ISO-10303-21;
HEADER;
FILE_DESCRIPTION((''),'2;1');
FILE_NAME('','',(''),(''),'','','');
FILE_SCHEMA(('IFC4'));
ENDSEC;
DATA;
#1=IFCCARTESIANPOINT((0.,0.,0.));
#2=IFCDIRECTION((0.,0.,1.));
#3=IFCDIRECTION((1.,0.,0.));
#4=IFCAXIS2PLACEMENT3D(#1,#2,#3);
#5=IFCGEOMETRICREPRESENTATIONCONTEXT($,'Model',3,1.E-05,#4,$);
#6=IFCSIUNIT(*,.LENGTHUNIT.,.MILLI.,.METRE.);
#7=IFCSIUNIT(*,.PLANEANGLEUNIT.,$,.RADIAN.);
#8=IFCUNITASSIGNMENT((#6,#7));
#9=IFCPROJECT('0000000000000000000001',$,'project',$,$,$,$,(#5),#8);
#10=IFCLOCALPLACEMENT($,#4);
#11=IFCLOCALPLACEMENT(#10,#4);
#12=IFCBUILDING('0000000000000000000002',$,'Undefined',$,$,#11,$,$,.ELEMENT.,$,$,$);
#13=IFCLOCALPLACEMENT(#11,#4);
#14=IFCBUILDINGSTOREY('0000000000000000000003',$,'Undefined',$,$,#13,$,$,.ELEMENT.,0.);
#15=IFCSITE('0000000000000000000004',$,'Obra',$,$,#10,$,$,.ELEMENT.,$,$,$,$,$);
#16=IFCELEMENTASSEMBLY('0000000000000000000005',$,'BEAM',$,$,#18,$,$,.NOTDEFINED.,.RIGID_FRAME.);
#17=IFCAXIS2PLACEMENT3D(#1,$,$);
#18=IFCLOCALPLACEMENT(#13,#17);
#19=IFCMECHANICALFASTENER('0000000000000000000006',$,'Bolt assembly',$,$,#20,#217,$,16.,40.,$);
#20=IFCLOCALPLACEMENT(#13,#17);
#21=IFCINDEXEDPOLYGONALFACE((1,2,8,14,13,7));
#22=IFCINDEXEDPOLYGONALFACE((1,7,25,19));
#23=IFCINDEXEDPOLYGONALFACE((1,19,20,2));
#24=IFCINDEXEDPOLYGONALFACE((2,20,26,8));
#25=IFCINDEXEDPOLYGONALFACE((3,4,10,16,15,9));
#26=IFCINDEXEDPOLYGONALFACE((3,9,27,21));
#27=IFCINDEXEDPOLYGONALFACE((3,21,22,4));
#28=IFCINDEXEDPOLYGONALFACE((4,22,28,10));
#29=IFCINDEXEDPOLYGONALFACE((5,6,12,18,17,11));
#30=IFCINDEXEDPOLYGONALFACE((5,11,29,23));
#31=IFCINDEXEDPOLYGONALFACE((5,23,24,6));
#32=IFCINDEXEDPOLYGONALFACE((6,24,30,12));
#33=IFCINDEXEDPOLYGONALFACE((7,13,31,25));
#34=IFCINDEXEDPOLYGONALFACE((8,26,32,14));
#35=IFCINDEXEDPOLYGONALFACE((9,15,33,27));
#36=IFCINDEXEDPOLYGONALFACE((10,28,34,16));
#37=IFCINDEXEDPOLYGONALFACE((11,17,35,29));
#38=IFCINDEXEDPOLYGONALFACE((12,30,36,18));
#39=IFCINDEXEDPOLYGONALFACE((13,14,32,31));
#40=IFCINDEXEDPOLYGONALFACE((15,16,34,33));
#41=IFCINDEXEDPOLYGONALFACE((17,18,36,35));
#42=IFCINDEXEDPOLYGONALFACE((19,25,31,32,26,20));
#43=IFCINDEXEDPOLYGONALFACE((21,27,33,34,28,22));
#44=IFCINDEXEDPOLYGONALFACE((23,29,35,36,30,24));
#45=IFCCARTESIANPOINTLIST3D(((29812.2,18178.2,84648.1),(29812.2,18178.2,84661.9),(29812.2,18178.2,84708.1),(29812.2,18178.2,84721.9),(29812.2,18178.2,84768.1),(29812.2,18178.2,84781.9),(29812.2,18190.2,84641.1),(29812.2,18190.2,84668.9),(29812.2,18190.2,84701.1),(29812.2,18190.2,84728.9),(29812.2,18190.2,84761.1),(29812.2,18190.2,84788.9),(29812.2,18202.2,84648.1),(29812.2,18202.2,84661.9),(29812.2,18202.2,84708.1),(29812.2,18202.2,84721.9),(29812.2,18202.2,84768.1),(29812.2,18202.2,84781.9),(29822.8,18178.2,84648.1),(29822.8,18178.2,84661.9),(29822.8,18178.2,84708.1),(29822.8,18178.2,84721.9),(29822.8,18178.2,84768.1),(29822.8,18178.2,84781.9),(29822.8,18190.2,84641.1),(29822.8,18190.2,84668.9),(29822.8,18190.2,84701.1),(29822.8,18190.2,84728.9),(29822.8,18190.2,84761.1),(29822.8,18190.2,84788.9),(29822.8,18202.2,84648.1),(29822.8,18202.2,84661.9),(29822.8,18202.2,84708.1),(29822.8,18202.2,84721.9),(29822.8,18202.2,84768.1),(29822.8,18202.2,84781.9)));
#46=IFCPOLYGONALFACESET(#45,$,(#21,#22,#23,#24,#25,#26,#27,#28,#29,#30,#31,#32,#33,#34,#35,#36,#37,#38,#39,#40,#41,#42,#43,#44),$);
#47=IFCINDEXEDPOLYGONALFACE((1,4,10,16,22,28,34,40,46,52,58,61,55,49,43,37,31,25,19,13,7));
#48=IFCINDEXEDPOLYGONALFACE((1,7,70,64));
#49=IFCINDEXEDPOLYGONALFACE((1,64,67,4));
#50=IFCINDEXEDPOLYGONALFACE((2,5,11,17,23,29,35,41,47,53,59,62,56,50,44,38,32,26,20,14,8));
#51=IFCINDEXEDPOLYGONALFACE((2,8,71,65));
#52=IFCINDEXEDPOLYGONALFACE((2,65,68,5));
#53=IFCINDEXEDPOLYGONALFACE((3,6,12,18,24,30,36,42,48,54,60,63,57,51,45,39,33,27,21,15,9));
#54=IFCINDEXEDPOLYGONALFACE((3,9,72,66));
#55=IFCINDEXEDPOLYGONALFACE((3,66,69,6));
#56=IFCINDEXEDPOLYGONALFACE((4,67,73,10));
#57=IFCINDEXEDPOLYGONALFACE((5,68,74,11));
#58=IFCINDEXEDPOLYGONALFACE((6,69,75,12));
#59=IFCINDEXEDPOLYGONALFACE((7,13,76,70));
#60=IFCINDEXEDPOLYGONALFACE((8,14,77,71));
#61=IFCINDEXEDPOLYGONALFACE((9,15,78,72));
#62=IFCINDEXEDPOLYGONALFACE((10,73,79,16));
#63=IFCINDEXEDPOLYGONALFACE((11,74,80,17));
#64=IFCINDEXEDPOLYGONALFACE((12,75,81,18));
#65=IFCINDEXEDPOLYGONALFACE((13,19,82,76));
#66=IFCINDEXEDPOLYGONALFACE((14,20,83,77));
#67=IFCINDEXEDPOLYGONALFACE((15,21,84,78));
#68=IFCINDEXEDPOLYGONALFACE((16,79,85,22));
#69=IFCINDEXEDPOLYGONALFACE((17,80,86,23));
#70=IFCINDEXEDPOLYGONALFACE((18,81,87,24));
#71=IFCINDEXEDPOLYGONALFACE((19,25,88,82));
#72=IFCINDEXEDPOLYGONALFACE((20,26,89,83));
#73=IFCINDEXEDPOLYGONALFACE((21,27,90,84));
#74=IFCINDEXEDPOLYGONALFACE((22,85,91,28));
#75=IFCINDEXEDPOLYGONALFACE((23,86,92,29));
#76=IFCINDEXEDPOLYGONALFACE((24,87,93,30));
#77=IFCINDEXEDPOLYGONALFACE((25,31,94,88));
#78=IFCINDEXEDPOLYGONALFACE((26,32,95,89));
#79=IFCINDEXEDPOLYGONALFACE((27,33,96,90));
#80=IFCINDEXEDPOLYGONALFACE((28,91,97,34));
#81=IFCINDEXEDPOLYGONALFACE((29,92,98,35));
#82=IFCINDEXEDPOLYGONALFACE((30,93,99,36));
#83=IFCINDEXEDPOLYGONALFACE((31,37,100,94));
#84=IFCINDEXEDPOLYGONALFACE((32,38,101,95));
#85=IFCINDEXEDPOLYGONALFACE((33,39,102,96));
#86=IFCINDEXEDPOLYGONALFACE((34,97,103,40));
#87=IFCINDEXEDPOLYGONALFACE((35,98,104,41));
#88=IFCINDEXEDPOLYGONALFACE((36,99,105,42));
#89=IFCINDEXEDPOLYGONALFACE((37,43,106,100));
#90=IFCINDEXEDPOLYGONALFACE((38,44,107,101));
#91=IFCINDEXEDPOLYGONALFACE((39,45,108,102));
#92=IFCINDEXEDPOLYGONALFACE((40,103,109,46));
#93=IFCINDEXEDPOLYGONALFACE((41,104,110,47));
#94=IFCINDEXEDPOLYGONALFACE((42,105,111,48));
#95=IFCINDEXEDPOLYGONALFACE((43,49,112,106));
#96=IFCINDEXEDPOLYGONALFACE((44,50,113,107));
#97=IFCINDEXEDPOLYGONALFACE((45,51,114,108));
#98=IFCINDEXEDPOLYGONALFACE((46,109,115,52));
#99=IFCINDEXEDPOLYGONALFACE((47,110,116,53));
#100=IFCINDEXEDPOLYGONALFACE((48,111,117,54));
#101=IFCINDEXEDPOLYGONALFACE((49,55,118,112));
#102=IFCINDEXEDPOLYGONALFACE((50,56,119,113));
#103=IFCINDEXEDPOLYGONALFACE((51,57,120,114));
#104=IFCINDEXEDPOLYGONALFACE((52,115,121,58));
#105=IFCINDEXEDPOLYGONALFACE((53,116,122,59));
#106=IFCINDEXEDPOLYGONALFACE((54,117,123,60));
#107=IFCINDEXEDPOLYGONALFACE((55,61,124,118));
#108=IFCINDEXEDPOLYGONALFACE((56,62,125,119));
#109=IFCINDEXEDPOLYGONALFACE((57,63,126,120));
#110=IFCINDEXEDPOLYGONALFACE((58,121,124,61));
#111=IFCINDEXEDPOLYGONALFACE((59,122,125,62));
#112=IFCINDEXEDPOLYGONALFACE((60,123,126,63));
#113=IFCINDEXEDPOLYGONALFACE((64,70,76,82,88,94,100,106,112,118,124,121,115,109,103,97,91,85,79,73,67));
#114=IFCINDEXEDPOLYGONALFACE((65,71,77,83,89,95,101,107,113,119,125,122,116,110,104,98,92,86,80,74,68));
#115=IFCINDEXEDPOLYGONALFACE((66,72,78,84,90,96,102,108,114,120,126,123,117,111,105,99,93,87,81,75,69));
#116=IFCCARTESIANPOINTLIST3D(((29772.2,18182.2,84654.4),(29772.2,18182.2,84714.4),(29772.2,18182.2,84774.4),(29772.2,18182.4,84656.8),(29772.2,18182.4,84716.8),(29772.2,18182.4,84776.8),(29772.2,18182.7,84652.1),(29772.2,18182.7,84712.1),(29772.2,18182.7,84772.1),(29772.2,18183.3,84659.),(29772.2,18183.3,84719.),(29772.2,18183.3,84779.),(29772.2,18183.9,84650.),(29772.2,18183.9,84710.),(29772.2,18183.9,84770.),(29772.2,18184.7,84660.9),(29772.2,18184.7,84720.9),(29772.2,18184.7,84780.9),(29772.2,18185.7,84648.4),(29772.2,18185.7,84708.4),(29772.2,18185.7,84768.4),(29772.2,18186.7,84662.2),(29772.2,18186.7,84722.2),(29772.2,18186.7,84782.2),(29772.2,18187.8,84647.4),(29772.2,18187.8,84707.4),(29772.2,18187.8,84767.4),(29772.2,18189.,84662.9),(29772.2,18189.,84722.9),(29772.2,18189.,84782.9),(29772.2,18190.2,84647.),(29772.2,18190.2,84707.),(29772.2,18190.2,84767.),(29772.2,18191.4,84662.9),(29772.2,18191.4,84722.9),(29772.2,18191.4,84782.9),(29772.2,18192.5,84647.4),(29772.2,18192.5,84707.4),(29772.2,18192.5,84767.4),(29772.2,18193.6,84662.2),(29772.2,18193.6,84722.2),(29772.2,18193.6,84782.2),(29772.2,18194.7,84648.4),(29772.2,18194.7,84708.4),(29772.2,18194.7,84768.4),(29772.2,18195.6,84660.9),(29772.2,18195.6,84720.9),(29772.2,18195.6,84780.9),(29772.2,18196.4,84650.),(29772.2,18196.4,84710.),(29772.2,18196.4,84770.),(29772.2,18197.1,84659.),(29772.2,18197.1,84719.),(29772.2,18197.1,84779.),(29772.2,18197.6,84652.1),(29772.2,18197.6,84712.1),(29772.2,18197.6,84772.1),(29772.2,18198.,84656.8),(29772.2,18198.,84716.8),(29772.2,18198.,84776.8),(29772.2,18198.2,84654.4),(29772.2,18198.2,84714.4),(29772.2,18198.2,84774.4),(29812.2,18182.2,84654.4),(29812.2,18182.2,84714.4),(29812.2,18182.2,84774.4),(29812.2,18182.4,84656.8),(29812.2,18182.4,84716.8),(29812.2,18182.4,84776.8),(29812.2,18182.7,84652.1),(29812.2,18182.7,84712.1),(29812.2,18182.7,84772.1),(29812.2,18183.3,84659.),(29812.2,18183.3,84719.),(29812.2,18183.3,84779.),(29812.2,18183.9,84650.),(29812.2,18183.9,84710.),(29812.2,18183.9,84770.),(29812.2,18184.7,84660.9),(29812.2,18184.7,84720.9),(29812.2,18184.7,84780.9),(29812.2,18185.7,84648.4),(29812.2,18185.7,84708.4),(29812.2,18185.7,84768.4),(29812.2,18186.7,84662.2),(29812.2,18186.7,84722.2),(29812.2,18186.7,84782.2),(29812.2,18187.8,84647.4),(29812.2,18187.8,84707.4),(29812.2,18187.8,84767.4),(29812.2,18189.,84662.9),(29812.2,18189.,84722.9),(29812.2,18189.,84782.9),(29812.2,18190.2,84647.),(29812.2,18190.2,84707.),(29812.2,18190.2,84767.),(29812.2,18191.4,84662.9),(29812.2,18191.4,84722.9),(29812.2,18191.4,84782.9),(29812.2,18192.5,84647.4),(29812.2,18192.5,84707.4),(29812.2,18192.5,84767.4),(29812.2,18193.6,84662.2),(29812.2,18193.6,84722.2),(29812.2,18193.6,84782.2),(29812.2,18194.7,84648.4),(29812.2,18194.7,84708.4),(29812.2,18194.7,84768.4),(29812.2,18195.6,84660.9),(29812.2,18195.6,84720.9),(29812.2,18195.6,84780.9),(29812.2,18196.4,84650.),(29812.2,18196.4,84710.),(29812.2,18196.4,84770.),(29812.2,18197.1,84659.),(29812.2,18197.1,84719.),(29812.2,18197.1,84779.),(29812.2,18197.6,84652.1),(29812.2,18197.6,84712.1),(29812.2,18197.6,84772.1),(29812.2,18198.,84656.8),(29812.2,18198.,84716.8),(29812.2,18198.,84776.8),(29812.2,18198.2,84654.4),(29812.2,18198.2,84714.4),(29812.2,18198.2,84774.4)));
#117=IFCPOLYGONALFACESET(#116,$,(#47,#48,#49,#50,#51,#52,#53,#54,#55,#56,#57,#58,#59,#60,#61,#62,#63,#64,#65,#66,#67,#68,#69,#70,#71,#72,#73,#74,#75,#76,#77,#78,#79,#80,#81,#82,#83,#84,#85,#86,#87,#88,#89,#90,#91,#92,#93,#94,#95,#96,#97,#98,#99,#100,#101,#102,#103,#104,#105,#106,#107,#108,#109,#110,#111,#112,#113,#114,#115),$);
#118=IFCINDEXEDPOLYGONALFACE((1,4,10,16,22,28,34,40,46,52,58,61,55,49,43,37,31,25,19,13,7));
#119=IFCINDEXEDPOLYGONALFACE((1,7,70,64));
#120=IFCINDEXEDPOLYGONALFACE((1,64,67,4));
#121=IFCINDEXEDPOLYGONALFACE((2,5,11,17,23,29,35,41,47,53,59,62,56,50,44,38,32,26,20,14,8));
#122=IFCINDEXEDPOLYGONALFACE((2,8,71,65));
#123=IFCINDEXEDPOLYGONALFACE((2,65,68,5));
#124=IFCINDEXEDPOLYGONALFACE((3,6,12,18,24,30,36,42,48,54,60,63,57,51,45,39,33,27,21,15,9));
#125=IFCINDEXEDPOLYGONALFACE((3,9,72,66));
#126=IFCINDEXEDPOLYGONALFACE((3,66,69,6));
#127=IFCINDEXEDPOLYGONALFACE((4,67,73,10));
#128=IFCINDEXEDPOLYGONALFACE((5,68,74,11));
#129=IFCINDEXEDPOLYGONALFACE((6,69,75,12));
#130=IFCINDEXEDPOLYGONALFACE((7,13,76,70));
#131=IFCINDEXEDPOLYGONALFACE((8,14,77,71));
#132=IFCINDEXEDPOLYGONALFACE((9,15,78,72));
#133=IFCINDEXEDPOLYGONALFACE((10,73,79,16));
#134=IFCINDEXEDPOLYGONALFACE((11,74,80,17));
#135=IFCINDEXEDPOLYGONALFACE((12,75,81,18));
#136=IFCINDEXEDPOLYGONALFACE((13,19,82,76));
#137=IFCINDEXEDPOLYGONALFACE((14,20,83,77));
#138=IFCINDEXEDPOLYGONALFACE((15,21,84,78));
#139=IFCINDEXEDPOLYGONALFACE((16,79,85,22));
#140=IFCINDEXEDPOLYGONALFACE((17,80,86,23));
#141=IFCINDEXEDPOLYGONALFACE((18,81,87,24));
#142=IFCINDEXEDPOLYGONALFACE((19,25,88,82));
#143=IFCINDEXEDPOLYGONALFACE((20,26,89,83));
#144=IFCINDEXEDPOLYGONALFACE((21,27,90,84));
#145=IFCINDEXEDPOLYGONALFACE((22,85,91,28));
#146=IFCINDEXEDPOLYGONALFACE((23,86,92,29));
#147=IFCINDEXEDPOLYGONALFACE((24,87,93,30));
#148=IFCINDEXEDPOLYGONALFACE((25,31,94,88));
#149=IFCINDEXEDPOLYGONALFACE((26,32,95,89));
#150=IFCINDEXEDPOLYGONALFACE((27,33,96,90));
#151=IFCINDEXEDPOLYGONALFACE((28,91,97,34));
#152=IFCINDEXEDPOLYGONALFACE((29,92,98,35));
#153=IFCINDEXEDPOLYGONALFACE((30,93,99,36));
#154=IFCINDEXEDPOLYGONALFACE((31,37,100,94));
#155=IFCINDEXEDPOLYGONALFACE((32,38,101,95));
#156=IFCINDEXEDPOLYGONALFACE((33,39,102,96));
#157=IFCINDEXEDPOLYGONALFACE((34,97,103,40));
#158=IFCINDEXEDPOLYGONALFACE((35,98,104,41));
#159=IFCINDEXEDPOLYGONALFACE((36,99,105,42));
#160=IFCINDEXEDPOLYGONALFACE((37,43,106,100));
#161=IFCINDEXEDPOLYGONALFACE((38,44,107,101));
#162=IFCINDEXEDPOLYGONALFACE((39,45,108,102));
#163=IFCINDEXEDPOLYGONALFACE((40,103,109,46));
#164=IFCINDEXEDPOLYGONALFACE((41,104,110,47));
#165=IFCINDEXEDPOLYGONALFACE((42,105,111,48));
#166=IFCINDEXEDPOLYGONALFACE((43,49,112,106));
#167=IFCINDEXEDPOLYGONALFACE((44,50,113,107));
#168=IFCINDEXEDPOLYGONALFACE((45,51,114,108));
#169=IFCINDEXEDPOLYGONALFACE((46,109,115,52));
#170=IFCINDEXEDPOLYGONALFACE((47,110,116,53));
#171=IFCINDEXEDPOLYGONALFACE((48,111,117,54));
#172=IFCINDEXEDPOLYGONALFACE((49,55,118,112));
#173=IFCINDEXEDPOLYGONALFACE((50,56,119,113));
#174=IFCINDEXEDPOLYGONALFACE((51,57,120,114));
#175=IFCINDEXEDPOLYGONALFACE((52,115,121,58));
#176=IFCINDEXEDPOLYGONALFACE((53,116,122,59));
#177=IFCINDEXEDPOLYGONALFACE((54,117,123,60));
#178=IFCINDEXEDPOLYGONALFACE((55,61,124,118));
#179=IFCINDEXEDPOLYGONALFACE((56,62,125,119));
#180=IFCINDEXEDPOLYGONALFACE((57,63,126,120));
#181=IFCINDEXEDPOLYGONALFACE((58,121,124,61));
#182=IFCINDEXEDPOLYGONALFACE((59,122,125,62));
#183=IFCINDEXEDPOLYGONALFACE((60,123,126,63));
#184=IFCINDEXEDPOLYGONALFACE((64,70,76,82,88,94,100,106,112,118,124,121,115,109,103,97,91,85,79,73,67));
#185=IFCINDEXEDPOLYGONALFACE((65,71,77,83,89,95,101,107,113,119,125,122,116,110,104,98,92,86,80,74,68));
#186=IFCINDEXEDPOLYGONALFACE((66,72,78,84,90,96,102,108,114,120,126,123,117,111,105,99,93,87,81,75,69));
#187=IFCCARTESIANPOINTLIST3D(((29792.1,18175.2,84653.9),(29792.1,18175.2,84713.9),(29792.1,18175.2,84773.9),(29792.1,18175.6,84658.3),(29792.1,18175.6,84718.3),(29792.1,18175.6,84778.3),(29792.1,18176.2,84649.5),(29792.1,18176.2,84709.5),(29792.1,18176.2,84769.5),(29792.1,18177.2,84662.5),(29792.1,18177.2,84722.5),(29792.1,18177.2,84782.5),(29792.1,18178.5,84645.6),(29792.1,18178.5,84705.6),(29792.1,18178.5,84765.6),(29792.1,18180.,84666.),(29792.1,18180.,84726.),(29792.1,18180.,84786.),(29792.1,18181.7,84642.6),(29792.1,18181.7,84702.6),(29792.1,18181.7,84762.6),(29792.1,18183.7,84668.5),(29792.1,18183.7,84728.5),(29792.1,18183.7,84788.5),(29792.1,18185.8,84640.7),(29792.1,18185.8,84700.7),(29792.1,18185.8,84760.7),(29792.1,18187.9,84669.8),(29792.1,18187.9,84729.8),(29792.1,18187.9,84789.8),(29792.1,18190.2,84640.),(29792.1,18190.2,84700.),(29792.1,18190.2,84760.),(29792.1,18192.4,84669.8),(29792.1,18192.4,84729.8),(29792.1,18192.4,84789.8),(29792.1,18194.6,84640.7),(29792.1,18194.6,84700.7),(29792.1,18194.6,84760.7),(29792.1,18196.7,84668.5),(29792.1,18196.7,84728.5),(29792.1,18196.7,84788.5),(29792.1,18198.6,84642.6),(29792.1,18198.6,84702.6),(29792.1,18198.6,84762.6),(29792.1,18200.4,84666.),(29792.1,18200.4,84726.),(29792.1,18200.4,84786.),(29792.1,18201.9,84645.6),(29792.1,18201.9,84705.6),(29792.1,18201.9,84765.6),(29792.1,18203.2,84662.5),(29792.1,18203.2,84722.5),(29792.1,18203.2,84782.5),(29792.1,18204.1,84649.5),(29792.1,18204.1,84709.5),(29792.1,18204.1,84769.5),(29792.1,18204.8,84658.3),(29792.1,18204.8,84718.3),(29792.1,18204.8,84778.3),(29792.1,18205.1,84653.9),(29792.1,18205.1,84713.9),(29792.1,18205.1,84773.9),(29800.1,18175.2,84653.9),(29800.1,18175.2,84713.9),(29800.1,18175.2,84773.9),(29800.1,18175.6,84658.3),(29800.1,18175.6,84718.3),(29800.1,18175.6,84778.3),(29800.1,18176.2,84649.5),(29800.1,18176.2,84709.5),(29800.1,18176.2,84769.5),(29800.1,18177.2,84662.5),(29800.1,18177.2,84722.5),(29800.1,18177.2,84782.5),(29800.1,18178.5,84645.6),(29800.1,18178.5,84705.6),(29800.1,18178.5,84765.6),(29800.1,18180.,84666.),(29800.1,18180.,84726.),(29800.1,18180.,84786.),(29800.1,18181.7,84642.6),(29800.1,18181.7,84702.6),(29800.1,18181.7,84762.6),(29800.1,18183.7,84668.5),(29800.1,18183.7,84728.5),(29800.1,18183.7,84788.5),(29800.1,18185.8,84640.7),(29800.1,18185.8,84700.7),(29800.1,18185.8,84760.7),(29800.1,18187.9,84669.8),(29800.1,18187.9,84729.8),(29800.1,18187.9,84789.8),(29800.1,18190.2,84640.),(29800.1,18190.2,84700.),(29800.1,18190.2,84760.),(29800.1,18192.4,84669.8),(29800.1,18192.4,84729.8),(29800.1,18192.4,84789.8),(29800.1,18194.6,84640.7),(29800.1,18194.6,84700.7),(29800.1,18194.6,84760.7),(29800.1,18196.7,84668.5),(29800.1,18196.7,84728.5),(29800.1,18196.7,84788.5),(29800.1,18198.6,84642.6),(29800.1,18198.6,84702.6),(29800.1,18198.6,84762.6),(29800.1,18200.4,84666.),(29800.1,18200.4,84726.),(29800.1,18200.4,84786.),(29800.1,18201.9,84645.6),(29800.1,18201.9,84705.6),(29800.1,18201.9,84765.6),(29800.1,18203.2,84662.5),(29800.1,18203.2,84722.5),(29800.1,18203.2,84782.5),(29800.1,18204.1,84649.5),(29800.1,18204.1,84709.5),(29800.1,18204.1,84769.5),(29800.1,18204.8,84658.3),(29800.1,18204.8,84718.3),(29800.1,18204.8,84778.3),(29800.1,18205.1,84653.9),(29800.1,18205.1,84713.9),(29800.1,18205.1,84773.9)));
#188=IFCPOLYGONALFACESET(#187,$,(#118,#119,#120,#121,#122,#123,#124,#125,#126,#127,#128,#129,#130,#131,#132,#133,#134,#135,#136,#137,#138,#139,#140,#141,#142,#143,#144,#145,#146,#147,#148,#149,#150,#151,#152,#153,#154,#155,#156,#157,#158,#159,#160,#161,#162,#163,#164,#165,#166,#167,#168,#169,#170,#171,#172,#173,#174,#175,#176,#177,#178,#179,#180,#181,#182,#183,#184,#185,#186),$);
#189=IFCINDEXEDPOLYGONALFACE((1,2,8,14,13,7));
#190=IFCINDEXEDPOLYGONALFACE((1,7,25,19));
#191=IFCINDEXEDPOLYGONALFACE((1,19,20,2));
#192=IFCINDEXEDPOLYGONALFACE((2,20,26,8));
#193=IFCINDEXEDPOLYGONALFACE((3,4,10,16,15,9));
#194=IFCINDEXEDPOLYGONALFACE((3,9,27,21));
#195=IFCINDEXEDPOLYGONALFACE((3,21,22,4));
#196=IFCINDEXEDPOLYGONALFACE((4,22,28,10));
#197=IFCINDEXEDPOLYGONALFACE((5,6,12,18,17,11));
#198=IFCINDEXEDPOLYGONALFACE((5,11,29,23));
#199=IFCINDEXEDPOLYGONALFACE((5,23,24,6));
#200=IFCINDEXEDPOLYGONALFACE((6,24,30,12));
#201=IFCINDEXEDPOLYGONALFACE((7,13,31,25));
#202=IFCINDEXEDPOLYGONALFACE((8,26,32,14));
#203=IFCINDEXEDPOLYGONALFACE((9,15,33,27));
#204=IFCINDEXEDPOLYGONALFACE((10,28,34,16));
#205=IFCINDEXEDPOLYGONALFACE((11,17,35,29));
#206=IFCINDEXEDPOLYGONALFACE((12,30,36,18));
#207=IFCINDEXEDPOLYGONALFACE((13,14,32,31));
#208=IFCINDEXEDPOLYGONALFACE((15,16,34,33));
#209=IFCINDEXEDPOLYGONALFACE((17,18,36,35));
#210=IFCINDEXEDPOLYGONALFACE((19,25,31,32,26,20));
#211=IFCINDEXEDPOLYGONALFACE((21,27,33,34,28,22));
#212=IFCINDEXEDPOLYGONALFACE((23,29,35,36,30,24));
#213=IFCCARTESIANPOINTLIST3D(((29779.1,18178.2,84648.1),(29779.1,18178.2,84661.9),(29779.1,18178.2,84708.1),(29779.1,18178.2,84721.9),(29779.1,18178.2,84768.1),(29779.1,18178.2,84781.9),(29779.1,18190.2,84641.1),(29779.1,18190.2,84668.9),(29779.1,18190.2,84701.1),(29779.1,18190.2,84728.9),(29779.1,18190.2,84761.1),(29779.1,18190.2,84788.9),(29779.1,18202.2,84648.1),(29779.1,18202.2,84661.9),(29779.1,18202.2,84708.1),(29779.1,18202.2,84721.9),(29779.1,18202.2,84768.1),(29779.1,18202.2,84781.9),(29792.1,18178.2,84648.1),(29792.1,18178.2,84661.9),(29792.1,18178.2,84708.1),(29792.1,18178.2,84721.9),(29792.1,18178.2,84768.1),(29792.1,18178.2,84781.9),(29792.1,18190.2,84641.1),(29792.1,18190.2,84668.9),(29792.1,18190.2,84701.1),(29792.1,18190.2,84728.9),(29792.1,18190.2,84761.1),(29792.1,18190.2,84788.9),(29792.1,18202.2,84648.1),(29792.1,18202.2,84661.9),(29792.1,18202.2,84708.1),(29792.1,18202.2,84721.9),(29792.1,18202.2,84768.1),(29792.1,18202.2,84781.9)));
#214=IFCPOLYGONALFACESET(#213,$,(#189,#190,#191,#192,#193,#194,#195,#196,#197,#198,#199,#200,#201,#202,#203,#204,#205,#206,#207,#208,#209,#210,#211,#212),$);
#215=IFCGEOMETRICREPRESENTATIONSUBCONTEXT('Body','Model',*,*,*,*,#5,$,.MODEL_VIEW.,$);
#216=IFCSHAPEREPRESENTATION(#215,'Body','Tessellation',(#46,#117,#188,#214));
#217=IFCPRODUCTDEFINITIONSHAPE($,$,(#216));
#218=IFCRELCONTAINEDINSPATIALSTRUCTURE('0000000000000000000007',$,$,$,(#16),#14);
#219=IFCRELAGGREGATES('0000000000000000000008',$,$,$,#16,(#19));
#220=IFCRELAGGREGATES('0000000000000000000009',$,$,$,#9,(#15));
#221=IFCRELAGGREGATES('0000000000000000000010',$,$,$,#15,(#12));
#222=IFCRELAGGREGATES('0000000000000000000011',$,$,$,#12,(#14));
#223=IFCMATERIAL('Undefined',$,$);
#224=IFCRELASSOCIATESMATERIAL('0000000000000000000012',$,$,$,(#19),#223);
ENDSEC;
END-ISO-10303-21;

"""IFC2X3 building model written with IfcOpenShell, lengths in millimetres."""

from ifc_helpers import new_model, si_unit, frame, origin_with_axes, origin_2d_with_axis, place, context, subcontext, project, spatial, polyline, circle, outline, extrude, source, transform, mapped, material, element, aggregate, save


model = new_model("IFC2X3")

# Units and contexts
model_context = context("Model", 3, precision=1e-05, world=origin_with_axes())
body_context = subcontext(model_context, "Body", "Model", "MODEL_VIEW")
ifc_project = project(units=[si_unit("LENGTHUNIT", "METRE", prefix="MILLI"), si_unit("PLANEANGLEUNIT", "RADIAN")], contexts=[model_context])

# Site, building, storey
site_placement = place(None, origin_with_axes())
site = spatial("IfcSite", under=ifc_project, at=site_placement, Name="Obra", CompositionType="ELEMENT")
building_placement = place(site_placement, origin_with_axes())
building = spatial("IfcBuilding", under=site, at=building_placement, Name="Undefined", CompositionType="ELEMENT")
storey_placement = place(building_placement, origin_with_axes())
storey = spatial("IfcBuildingStorey", under=building, at=storey_placement, Name="Undefined", CompositionType="ELEMENT", Elevation=0.0)

# Shared definitions
ifc_material_1 = material(Name="Undefined")

# Element assembly, mechanical fastener
shared_shape_1 = source(origin_with_axes(), body_context, "Body", "SweptSolid", [
    extrude(outline(polyline([(13.9, 0.0), (6.9, 12.0), (-6.9, 12.0), (-13.9, 0.0), (-6.9, -12.0), (6.9, -12.0), (13.9, 0.0)])), frame((0.0, -19.7, 0.0), z_axis=(0.0, 1.0, 0.0), x_axis=(1.0, 0.0, 0.0)), (0.0, 0.0, 1.0), 10.6),
    extrude(circle(Radius=8.0, at=origin_2d_with_axis()), frame((0.0, -9.1, 0.0), z_axis=(0.0, 1.0, 0.0), x_axis=(1.0, 0.0, 0.0)), (0.0, 0.0, 1.0), 40.0),
    extrude(circle(Radius=15.0, at=origin_2d_with_axis()), frame((0.0, 3.0, 0.0), z_axis=(0.0, 1.0, 0.0), x_axis=(1.0, 0.0, 0.0)), (0.0, 0.0, 1.0), 8.0),
    extrude(outline(polyline([(13.9, 0.0), (6.9, 12.0), (-6.9, 12.0), (-13.9, 0.0), (-6.9, -12.0), (6.9, -12.0), (13.9, 0.0)])), frame((0.0, 11.0, 0.0), z_axis=(0.0, 1.0, 0.0), x_axis=(1.0, 0.0, 0.0)), (0.0, 0.0, 1.0), 13.0),
])
assembly_1_placement = place(storey_placement, origin_with_axes())
assembly_1 = element("IfcElementAssembly", 1, at=assembly_1_placement, inside=storey, Name="BEAM", AssemblyPlace="NOTDEFINED", PredefinedType="RIGID_FRAME")
mechanical_fastener_1_placement = place(assembly_1_placement, frame((29803.1, 18140.2, 84835.0), z_axis=(-0.000002, 1.0, 0.0), x_axis=(0.0, 0.0, -1.0)))
mechanical_fastener_1 = element("IfcMechanicalFastener", 2, at=mechanical_fastener_1_placement, material=ifc_material_1, Name="Bolt assembly", NominalDiameter=16.0, NominalLength=40.0, context=body_context, shape_type="MappedRepresentation", body=[
    mapped(shared_shape_1, transform((60.0, 0.0, 50.0))),
    mapped(shared_shape_1, transform((120.0, 0.0, 50.0))),
    mapped(shared_shape_1, transform((180.0, 0.0, 50.0))),
])

aggregate(assembly_1, [mechanical_fastener_1])

save(model, "model.ifc")
